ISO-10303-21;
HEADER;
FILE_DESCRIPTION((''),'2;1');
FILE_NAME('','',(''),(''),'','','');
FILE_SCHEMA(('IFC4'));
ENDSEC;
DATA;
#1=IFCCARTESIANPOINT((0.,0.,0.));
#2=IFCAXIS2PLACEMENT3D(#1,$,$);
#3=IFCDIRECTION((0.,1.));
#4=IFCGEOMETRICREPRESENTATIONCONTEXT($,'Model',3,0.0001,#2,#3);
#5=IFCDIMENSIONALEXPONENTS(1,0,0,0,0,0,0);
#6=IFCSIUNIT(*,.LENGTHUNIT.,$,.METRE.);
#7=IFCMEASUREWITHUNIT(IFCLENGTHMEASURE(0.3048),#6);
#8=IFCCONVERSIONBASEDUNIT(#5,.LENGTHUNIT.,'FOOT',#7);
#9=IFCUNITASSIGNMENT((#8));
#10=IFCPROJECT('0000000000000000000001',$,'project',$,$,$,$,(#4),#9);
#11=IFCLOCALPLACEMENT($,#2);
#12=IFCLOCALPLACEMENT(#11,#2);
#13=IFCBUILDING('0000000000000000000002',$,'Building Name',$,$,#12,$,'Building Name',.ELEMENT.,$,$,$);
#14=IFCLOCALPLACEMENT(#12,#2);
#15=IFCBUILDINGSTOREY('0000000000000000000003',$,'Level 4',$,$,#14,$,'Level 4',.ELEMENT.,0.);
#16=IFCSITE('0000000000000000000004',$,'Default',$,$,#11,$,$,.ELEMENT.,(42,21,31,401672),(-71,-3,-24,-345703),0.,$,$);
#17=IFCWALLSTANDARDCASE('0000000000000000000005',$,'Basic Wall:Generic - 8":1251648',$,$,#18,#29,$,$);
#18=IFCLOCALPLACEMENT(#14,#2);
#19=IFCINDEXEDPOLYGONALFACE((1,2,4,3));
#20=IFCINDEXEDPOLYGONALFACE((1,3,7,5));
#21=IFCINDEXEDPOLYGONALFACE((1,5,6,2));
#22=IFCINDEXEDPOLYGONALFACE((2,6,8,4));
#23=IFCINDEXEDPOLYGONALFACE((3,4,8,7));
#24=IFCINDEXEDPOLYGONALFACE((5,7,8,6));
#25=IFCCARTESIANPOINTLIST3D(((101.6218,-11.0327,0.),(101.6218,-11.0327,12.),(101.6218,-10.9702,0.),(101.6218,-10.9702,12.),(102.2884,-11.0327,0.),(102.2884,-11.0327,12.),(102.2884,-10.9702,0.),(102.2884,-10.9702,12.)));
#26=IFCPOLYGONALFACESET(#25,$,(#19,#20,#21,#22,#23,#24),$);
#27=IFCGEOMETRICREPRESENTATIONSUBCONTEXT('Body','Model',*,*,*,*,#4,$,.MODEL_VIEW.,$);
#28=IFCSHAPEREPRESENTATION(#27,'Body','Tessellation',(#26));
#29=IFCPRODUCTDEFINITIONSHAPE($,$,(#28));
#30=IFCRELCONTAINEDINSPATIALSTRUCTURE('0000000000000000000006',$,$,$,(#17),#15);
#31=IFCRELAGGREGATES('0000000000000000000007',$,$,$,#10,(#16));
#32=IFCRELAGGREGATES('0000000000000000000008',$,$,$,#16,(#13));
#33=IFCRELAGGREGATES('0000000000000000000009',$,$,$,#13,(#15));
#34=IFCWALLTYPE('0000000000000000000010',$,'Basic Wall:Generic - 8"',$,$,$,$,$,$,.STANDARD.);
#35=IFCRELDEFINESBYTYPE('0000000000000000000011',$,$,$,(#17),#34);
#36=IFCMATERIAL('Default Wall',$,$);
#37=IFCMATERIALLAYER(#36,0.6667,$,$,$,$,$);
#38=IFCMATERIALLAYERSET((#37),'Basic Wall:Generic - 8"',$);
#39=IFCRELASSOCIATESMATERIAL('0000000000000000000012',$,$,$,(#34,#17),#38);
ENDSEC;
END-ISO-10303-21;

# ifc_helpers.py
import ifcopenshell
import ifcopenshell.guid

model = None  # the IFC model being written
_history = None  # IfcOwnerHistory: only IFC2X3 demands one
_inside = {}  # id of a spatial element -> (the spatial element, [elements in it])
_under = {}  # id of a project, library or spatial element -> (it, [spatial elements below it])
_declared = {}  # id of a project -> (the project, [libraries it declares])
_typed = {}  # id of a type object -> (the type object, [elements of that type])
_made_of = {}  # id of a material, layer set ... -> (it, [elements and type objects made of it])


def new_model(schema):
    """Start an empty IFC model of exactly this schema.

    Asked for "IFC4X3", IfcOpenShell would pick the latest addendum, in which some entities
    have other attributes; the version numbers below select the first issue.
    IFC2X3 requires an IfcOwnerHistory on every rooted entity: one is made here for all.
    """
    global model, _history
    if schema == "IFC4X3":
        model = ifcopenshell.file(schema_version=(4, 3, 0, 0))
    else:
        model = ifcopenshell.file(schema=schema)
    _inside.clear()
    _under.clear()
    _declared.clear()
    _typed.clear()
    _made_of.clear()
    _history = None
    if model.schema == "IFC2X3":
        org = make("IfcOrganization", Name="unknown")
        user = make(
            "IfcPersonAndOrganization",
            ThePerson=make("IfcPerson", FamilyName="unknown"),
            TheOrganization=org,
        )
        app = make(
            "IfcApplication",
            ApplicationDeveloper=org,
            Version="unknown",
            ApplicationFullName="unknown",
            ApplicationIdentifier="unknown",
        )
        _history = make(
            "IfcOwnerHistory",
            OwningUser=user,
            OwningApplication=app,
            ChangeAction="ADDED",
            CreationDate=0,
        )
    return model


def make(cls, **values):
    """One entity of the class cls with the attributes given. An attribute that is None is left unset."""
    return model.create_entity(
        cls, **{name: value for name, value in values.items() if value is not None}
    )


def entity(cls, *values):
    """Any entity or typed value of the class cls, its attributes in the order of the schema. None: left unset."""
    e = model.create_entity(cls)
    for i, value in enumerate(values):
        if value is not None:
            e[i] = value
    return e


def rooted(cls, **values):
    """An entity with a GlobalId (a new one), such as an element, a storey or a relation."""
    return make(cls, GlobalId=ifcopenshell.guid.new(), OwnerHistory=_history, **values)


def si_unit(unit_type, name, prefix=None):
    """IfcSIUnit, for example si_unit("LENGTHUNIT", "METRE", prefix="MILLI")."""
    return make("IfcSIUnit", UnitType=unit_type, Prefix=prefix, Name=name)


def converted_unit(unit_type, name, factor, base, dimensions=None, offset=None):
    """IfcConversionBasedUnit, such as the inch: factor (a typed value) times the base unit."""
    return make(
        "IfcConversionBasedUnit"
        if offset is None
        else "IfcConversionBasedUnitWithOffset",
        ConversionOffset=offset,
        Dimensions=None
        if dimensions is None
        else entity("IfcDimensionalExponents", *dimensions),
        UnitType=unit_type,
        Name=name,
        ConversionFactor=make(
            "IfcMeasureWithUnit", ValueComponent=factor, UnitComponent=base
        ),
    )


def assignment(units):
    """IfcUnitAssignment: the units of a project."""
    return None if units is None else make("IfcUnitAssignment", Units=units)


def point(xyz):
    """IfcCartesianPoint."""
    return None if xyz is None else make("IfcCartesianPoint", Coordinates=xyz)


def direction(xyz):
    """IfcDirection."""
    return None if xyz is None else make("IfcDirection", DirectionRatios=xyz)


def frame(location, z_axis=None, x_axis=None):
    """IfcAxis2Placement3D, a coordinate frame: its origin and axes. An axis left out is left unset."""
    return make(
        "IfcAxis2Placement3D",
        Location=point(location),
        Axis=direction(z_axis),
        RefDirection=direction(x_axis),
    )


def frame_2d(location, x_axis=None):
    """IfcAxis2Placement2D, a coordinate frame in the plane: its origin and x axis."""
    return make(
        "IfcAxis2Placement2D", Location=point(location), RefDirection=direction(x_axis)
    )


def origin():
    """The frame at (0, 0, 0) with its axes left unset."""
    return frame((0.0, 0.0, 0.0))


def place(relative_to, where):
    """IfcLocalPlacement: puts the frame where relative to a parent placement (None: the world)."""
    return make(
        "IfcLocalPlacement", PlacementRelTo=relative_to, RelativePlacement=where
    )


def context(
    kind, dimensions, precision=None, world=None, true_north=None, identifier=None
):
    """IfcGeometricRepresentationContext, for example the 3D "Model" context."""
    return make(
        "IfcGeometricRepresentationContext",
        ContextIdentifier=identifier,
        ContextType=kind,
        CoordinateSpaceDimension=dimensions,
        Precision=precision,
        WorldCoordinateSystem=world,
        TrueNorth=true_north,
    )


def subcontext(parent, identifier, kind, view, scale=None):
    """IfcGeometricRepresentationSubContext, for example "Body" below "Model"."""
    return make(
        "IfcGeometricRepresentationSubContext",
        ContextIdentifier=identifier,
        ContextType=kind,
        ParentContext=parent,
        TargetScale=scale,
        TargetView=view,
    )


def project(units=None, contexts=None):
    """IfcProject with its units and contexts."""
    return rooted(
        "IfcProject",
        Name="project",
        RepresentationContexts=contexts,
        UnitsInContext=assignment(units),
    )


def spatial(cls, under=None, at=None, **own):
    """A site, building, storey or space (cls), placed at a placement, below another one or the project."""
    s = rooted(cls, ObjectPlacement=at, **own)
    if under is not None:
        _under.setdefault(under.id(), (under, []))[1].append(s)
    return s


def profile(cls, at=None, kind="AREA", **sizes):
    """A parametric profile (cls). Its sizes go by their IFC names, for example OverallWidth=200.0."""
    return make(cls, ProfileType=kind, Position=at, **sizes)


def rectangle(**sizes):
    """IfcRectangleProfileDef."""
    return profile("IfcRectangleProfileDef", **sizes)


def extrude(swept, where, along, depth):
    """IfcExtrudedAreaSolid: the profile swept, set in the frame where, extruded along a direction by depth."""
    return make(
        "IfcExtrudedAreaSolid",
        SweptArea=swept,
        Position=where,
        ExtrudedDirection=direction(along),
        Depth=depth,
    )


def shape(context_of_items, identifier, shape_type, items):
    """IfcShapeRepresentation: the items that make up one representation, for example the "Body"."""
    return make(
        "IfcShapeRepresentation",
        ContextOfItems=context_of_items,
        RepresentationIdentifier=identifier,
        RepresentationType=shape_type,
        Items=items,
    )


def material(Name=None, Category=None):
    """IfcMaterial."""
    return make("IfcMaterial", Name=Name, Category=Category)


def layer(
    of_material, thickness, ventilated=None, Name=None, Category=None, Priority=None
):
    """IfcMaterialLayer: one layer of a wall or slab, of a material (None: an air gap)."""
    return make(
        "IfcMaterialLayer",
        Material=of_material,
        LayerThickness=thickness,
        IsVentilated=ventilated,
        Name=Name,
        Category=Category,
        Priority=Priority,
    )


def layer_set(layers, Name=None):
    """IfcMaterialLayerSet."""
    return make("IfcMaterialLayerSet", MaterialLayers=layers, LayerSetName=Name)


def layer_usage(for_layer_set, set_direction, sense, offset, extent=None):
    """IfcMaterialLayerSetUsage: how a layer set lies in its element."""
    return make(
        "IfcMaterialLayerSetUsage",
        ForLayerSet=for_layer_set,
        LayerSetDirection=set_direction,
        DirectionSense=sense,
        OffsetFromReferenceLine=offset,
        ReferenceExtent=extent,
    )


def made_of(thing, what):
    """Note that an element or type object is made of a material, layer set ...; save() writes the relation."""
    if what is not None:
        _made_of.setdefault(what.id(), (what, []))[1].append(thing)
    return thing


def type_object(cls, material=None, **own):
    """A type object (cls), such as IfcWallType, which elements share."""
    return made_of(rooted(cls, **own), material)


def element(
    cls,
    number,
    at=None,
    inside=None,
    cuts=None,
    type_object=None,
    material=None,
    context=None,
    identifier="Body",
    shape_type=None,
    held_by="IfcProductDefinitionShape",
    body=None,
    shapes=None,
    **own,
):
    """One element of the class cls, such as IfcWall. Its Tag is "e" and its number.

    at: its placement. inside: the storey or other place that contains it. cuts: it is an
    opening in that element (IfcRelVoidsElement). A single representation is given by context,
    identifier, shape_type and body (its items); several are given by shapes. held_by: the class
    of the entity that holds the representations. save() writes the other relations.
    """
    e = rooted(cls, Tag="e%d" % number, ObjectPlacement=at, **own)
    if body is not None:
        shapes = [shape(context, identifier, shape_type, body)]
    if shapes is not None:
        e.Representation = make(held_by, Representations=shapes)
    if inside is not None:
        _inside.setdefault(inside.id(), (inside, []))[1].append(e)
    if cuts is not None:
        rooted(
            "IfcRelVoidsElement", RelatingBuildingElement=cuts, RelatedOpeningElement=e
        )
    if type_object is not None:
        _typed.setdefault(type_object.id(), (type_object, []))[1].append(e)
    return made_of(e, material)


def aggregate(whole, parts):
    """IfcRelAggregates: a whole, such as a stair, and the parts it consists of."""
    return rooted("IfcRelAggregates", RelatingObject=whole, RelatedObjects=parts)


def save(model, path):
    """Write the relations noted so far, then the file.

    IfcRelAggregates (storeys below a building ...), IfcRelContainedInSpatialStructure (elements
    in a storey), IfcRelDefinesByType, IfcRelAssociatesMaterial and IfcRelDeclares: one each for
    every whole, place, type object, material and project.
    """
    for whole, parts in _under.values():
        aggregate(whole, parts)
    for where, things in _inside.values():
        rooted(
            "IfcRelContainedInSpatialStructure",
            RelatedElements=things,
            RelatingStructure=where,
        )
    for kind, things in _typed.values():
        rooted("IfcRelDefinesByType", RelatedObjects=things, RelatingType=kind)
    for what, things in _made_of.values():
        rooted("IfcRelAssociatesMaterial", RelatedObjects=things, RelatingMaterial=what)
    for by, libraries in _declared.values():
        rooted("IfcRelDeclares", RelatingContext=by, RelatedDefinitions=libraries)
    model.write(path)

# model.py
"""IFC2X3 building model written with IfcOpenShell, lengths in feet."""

from ifc_helpers import new_model, entity, si_unit, converted_unit, direction, frame, frame_2d, origin, place, context, subcontext, project, spatial, rectangle, extrude, material, layer, layer_set, layer_usage, type_object, element, save


model = new_model("IFC2X3")

# Units and contexts
model_context = context("Model", 3, precision=0.0001, world=origin(), true_north=direction((0.0, 1.0)))
body_context = subcontext(model_context, "Body", "Model", "MODEL_VIEW")
ifc_project = project(units=[converted_unit("LENGTHUNIT", "FOOT", entity("IfcLengthMeasure", 0.3048), si_unit("LENGTHUNIT", "METRE"), dimensions=[1, 0, 0, 0, 0, 0, 0])], contexts=[model_context])

# Site, building, storey
site_placement = place(None, origin())
site = spatial("IfcSite", under=ifc_project, at=site_placement, Name="Default", CompositionType="ELEMENT", RefLatitude=(42, 21, 31, 401672), RefLongitude=(-71, -3, -24, -345703), RefElevation=0.0)
building_placement = place(site_placement, origin())
building = spatial("IfcBuilding", under=site, at=building_placement, Name="Building Name", LongName="Building Name", CompositionType="ELEMENT")
storey_placement = place(building_placement, origin())
storey = spatial("IfcBuildingStorey", under=building, at=storey_placement, Name="Level 4", LongName="Level 4", CompositionType="ELEMENT", Elevation=0.0)

# Wall
ifc_material_1 = material(Name="Default Wall")
ifc_layer_1 = layer(ifc_material_1, 0.6667)
ifc_layer_set_1 = layer_set([ifc_layer_1], Name="Basic Wall:Generic - 8\"")
wall_type_1 = type_object("IfcWallType", Name="Basic Wall:Generic - 8\"", PredefinedType="STANDARD", material=ifc_layer_set_1)
ifc_layer_usage_1 = layer_usage(ifc_layer_set_1, "AXIS2", "NEGATIVE", 0.3333)
wall_1_placement = place(storey_placement, frame((101.9551, -10.9702, 0.0), z_axis=(0.0, 0.0, 1.0), x_axis=(0.0, -1.0, 0.0)))
element("IfcWallStandardCase", 1, at=wall_1_placement, inside=storey, type_object=wall_type_1, material=ifc_layer_usage_1, Name="Basic Wall:Generic - 8\":1251648", context=body_context, shape_type="SweptSolid", body=[
    extrude(rectangle(XDim=0.0625, YDim=0.6667, at=frame_2d((0.0312, 0.0), x_axis=(-1.0, 0.0))), origin(), (0.0, 0.0, 1.0), 12.0),
])

save(model, "model.ifc")
